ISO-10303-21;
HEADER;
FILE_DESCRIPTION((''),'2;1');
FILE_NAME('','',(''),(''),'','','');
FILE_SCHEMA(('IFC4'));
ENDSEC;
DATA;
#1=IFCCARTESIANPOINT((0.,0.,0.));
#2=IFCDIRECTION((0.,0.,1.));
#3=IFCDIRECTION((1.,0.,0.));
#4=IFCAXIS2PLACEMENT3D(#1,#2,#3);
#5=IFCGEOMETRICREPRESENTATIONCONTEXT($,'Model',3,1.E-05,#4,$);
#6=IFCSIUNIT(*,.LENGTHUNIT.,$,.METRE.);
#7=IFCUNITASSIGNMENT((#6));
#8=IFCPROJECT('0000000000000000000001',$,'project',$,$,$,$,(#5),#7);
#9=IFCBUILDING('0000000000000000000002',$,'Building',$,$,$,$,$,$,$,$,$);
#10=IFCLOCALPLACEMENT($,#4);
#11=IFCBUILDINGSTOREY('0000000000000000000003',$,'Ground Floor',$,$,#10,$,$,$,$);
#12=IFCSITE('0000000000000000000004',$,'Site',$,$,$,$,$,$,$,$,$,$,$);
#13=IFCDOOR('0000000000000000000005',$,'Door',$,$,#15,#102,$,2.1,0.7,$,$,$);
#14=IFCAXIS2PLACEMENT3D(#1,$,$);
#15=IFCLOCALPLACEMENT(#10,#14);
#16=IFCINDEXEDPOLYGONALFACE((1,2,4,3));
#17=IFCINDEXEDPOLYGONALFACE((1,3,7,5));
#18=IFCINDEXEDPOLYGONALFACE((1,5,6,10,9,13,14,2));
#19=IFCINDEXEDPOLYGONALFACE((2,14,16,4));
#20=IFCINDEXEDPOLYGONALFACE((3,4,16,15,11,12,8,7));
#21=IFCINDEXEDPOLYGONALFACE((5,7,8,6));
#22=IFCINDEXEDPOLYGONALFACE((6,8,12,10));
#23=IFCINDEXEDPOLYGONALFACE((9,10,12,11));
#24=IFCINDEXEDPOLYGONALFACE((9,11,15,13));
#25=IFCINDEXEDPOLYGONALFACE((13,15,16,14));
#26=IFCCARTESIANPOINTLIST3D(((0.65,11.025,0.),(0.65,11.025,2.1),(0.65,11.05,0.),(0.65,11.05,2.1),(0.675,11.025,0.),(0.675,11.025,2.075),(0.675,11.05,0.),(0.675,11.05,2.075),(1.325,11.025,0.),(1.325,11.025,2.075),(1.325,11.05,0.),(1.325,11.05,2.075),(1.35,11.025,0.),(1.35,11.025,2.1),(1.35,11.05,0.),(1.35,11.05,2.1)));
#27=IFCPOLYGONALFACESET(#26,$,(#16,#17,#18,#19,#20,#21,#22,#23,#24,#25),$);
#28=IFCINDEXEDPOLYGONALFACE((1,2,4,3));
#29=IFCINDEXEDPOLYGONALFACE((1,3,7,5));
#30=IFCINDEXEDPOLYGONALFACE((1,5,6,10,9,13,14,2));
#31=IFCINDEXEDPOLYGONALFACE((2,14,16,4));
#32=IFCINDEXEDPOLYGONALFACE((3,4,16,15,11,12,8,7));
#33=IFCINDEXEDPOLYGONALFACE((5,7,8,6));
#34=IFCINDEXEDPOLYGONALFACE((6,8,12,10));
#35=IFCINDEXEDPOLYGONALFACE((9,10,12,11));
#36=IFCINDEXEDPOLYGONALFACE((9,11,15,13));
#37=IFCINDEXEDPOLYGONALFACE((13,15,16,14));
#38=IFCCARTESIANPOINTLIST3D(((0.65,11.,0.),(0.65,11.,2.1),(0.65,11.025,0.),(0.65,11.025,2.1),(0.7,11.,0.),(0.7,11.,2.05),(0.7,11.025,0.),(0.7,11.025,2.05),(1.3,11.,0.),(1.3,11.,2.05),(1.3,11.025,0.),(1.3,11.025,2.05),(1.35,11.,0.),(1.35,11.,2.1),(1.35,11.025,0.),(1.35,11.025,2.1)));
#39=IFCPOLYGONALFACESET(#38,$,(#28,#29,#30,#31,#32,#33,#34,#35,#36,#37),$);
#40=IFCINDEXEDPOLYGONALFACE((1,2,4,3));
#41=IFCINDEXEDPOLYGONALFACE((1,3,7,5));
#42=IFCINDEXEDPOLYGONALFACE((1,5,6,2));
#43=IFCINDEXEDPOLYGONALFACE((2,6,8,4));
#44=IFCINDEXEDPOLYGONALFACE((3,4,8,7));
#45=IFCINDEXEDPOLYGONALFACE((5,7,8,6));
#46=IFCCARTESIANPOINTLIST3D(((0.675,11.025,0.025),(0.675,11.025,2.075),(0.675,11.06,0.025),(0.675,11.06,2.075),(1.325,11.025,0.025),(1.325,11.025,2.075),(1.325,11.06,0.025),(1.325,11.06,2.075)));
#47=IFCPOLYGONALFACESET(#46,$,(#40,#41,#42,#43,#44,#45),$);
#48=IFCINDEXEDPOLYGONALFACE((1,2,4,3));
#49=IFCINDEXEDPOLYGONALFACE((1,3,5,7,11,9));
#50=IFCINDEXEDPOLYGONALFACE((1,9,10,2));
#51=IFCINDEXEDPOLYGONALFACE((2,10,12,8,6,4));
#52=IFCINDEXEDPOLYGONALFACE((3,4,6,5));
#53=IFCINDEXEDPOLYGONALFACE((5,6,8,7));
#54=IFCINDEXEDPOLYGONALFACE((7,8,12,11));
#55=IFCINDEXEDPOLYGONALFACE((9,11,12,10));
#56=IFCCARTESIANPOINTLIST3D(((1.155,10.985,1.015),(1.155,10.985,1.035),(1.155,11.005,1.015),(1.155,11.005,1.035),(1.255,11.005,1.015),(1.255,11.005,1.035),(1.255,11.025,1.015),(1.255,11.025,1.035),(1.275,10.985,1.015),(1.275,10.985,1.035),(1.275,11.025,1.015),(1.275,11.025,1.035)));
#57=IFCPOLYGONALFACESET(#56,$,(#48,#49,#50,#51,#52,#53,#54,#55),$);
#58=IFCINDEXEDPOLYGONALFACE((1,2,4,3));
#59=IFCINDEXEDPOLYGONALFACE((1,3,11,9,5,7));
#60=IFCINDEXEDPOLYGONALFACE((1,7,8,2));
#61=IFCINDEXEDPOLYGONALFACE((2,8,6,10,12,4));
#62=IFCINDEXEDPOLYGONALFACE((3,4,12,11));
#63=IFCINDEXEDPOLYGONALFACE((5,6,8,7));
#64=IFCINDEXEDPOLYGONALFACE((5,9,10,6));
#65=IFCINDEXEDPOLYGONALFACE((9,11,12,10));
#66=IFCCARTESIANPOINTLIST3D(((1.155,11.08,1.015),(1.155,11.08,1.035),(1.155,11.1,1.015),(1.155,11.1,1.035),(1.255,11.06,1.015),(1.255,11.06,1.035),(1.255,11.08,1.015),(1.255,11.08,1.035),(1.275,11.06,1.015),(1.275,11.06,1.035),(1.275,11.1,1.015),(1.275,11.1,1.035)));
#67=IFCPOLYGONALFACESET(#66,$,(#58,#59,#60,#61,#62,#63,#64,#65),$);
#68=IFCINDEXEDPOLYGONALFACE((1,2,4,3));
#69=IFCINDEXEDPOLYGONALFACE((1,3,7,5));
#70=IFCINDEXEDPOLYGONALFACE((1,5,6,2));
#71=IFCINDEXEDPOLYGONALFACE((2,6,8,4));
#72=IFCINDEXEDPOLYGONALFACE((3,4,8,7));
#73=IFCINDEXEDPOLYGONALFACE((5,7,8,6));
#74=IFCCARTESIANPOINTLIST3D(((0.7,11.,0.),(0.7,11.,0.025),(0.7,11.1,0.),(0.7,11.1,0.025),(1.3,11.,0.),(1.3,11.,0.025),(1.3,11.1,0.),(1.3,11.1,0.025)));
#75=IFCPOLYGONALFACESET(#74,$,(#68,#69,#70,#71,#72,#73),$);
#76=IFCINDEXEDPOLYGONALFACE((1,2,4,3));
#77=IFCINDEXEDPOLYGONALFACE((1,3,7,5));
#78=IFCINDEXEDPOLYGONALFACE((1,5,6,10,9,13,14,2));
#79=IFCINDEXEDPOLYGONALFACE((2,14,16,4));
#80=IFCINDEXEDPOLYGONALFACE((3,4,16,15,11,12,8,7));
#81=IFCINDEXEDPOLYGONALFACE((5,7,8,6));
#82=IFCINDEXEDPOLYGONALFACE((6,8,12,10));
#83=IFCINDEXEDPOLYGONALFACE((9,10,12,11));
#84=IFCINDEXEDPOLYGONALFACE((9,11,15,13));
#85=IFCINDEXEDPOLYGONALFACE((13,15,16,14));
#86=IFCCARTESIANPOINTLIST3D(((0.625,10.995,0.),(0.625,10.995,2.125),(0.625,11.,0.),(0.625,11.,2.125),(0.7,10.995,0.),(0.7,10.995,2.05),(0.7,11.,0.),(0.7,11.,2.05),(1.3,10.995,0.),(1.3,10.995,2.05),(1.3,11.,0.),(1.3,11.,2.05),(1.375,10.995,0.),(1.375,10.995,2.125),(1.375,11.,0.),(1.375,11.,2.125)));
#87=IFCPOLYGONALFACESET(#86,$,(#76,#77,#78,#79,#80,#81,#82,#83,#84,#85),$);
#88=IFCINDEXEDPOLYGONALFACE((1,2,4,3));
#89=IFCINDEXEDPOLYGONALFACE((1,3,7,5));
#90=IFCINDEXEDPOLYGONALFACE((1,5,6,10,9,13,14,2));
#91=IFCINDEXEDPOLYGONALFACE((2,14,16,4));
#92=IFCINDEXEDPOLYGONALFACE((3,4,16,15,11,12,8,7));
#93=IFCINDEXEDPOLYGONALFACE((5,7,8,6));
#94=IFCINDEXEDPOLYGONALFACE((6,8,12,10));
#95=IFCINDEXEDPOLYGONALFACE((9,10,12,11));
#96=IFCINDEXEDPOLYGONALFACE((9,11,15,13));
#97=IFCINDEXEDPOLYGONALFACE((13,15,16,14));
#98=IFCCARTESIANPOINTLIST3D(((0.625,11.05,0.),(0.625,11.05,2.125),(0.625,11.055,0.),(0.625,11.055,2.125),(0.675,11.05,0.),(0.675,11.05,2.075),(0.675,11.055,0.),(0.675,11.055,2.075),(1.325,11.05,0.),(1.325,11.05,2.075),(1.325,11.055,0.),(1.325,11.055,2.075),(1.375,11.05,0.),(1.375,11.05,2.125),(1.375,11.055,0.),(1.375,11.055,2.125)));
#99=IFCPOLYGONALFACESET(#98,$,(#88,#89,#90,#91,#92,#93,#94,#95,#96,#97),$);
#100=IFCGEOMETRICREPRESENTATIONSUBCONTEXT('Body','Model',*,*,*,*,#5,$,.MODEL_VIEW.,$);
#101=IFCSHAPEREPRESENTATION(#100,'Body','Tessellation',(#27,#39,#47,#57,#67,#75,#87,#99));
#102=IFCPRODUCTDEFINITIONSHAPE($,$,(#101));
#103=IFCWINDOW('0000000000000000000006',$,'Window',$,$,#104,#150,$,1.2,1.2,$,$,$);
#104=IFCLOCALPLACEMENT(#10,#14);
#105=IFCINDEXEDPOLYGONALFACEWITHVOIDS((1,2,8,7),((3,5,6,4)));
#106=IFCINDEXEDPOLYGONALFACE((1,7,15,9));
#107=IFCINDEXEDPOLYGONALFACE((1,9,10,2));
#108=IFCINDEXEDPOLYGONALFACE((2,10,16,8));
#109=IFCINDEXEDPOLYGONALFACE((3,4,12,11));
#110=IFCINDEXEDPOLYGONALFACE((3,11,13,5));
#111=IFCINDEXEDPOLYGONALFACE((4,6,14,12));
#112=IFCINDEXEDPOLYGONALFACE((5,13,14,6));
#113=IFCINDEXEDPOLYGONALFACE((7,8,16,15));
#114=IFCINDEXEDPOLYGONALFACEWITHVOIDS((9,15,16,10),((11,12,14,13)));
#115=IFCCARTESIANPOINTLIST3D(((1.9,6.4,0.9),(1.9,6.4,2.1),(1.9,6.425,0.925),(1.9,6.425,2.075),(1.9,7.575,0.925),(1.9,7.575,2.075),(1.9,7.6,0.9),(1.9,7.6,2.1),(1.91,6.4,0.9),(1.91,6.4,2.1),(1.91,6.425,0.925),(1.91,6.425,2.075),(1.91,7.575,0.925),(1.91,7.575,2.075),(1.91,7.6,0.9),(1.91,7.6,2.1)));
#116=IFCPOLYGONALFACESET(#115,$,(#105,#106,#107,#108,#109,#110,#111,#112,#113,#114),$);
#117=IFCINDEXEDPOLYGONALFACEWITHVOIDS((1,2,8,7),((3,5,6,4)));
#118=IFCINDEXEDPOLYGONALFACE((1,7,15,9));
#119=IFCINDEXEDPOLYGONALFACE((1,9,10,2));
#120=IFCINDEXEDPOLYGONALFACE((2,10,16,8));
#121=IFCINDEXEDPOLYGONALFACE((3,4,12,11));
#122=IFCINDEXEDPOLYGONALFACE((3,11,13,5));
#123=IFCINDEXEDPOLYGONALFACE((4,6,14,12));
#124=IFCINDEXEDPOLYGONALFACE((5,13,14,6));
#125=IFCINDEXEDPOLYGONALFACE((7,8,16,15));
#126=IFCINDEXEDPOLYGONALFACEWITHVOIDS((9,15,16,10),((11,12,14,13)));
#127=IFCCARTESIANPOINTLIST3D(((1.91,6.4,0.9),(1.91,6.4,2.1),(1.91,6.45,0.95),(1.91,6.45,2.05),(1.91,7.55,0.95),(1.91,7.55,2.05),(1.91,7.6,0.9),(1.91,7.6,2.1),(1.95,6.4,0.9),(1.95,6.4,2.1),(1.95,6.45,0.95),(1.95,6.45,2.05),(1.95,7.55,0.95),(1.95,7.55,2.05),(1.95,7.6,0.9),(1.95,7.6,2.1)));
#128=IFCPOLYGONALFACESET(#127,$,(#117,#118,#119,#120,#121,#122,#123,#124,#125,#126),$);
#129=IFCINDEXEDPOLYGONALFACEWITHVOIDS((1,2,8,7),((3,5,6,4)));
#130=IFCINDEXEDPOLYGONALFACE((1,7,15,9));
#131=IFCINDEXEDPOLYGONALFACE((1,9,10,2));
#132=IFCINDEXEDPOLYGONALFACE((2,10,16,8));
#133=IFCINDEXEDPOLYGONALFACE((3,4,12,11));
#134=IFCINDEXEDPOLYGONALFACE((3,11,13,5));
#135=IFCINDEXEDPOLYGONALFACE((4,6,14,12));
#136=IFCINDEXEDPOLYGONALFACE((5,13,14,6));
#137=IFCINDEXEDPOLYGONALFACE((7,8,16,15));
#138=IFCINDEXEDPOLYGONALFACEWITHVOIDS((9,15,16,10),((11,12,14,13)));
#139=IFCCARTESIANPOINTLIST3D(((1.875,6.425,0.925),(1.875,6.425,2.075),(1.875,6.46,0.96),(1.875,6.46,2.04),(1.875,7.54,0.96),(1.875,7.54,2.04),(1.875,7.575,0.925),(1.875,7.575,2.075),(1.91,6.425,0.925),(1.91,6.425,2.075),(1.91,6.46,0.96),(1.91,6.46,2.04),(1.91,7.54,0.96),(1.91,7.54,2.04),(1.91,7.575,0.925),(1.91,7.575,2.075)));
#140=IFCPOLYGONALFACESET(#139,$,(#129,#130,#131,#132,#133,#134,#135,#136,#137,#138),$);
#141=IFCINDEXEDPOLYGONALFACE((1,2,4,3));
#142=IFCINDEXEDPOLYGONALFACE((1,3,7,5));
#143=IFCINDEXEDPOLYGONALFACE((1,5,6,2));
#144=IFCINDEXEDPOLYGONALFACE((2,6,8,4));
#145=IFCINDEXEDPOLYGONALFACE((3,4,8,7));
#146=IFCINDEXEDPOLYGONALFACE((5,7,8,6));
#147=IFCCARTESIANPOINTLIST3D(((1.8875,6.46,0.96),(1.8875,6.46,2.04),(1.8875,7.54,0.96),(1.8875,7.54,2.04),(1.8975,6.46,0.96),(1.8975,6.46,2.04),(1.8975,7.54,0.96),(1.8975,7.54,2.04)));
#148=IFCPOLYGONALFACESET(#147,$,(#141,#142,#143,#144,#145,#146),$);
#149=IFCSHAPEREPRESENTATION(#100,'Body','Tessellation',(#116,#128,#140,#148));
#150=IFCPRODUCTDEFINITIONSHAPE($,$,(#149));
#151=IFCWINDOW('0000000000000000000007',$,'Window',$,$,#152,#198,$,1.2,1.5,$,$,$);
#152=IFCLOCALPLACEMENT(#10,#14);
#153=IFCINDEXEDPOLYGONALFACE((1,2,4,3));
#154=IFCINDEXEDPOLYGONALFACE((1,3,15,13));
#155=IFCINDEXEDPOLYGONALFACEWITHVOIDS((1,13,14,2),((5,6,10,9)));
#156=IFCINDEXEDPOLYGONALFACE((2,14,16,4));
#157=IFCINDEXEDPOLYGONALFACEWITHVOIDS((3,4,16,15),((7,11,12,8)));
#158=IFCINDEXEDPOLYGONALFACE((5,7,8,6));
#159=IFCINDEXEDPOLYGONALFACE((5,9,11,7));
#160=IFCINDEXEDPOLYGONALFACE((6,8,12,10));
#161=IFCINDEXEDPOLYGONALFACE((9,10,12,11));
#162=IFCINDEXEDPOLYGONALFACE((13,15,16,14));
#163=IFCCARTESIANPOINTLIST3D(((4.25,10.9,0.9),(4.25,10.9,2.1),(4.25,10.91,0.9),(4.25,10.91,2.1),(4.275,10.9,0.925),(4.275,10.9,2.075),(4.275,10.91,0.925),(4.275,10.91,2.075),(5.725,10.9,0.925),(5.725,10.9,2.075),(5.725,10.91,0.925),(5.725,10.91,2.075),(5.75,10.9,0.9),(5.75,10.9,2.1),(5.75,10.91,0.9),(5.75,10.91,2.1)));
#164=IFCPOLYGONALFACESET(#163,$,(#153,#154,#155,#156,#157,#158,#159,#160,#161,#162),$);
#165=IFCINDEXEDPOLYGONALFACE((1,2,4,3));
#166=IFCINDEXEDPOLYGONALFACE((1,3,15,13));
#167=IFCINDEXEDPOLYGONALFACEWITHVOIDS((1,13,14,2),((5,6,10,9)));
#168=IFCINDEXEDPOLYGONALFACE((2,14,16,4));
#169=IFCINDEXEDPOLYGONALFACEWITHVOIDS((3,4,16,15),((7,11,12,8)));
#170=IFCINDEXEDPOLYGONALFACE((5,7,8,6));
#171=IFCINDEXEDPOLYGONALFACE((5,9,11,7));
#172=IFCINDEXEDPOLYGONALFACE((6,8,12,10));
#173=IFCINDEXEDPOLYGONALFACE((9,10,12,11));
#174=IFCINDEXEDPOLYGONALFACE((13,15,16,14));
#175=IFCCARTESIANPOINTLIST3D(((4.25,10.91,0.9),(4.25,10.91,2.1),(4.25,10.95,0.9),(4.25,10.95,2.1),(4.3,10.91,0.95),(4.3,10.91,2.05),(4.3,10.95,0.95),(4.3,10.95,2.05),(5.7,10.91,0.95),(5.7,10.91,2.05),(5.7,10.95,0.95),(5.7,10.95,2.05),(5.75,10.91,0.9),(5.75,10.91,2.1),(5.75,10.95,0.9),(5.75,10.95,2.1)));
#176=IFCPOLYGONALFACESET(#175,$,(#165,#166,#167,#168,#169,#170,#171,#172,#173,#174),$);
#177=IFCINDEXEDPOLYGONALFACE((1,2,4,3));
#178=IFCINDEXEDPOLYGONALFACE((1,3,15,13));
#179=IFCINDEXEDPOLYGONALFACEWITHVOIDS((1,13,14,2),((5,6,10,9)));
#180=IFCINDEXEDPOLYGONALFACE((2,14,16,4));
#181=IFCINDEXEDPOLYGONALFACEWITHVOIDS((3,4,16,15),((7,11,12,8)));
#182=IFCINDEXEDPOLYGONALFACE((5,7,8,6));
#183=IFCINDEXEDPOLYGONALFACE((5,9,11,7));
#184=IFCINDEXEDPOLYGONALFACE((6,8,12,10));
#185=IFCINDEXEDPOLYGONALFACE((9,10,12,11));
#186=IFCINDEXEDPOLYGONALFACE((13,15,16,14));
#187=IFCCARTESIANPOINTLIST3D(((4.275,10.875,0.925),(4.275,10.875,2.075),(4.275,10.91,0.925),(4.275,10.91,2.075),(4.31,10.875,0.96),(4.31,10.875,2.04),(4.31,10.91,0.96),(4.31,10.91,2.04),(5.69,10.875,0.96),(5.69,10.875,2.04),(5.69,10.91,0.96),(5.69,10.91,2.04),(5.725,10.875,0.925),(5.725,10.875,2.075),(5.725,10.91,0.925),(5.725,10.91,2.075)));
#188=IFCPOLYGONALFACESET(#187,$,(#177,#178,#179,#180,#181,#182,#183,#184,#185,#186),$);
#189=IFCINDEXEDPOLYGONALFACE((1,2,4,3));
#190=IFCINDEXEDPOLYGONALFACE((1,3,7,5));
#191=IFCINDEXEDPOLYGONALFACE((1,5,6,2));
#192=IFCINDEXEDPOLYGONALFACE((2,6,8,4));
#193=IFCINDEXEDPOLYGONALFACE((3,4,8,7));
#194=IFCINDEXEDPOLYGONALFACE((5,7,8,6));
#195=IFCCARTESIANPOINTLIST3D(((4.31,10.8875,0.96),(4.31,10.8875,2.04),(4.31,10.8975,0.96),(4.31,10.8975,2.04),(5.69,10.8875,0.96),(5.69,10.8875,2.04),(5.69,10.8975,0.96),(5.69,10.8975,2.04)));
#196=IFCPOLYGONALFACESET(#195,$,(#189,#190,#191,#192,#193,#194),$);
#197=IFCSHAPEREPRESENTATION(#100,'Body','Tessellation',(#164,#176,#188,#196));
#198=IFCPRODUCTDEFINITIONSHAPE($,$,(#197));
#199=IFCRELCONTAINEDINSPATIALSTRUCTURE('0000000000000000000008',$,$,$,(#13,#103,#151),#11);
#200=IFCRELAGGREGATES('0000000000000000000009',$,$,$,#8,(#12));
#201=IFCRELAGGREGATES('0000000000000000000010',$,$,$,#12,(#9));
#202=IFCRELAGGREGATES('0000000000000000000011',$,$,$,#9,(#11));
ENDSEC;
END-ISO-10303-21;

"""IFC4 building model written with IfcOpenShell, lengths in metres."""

from ifc_helpers import new_model, si_unit, frame, origin_with_axes, place, context, subcontext, project, spatial, line, indexed_curve, outline, extrude, element, save


model = new_model("IFC4")

# Units and contexts
model_context = context("Model", 3, precision=1e-05, world=origin_with_axes())
body_context = subcontext(model_context, "Body", "Model", "MODEL_VIEW")
ifc_project = project(units=[si_unit("LENGTHUNIT", "METRE")], contexts=[model_context])

# Site, building, storey
site = spatial("IfcSite", under=ifc_project, Name="Site")
building = spatial("IfcBuilding", under=site, Name="Building")
storey_placement = place(None, origin_with_axes())
storey = spatial("IfcBuildingStorey", under=building, at=storey_placement, Name="Ground Floor")

# Door
door_1_placement = place(storey_placement, frame((0.65, 11.0, 0.0), z_axis=(0.0, 0.0, 1.0), x_axis=(1.0, 0.0, 0.0)))
element("IfcDoor", 1, at=door_1_placement, inside=storey, Name="Door", OverallHeight=2.1, OverallWidth=0.7, context=body_context, shape_type="SweptSolid", body=[
    extrude(outline(indexed_curve([(0.0, 0.0), (0.0, 2.1), (0.7, 2.1), (0.7, 0.0), (0.675, 0.0), (0.675, 2.075), (0.025, 2.075), (0.025, 0.0)], segments=[line(1, 2, 3, 4, 5, 6, 7, 8, 1)])), frame((0.0, 0.025, 0.0), z_axis=(0.0, -1.0, 0.0), x_axis=(1.0, 0.0, 0.0)), (0.0, 0.0, -1.0), 0.025),
    extrude(outline(indexed_curve([(0.0, 0.0), (0.0, 2.1), (0.7, 2.1), (0.7, 0.0), (0.65, 0.0), (0.65, 2.05), (0.05, 2.05), (0.05, 0.0)], segments=[line(1, 2, 3, 4, 5, 6, 7, 8, 1)])), frame((0.0, 0.0, 0.0), z_axis=(0.0, -1.0, 0.0), x_axis=(1.0, 0.0, 0.0)), (0.0, 0.0, -1.0), 0.025),
    extrude(outline(indexed_curve([(0.0, 0.0), (0.65, 0.0), (0.65, 0.035), (0.0, 0.035)], segments=[line(1, 2, 3, 4, 1)])), frame((0.025, 0.025, 0.025), z_axis=(0.0, 0.0, 1.0), x_axis=(1.0, 0.0, 0.0)), (0.0, 0.0, 1.0), 2.05),
    extrude(outline(indexed_curve([(0.0, 0.0), (0.0, -0.04), (-0.12, -0.04), (-0.12, -0.02), (-0.02, -0.02), (-0.02, 0.0)], segments=[line(1, 2, 3, 4, 5, 6, 1)])), frame((0.625, 0.025, 1.015), z_axis=(0.0, 0.0, 1.0), x_axis=(1.0, 0.0, 0.0)), (0.0, 0.0, 1.0), 0.02),
    extrude(outline(indexed_curve([(0.0, 0.0), (0.0, 0.04), (-0.12, 0.04), (-0.12, 0.02), (-0.02, 0.02), (-0.02, 0.0)], segments=[line(1, 2, 3, 4, 5, 6, 1)])), frame((0.625, 0.06, 1.015), z_axis=(0.0, 0.0, 1.0), x_axis=(1.0, 0.0, 0.0)), (0.0, 0.0, 1.0), 0.02),
    extrude(outline(indexed_curve([(0.0, 0.0), (0.6, 0.0), (0.6, 0.1), (0.0, 0.1)], segments=[line(1, 2, 3, 4, 1)])), frame((0.05, 0.0, 0.0), z_axis=(0.0, 0.0, 1.0), x_axis=(1.0, 0.0, 0.0)), (0.0, 0.0, 1.0), 0.025),
    extrude(outline(indexed_curve([(0.0, 0.0), (0.0, 2.125), (0.75, 2.125), (0.75, 0.0), (0.675, 0.0), (0.675, 2.05), (0.075, 2.05), (0.075, 0.0)], segments=[line(1, 2, 3, 4, 5, 6, 7, 8, 1)])), frame((-0.025, -0.005, 0.0), z_axis=(0.0, -1.0, 0.0), x_axis=(1.0, 0.0, 0.0)), (0.0, 0.0, -1.0), 0.005),
    extrude(outline(indexed_curve([(0.0, 0.0), (0.0, 2.125), (0.75, 2.125), (0.75, 0.0), (0.7, 0.0), (0.7, 2.075), (0.05, 2.075), (0.05, 0.0)], segments=[line(1, 2, 3, 4, 5, 6, 7, 8, 1)])), frame((-0.025, 0.05, 0.0), z_axis=(0.0, -1.0, 0.0), x_axis=(1.0, 0.0, 0.0)), (0.0, 0.0, -1.0), 0.005),
])

# Windows
window_1_placement = place(storey_placement, frame((2.0, 6.4, 0.9), z_axis=(0.0, 0.0, 1.0), x_axis=(0.0, 1.0, 0.0)))
element("IfcWindow", 2, at=window_1_placement, inside=storey, Name="Window", OverallHeight=1.2, OverallWidth=1.2, context=body_context, shape_type="SweptSolid", body=[
    extrude(outline(indexed_curve([(0.0, 0.0), (1.2, 0.0), (1.2, 1.2), (0.0, 1.2)], segments=[line(1, 2, 3, 4, 1)]), holes=[indexed_curve([(0.025, 0.025), (1.175, 0.025), (1.175, 1.175), (0.025, 1.175)], segments=[line(1, 2, 3, 4, 1)])]), frame((0.0, 0.09, 0.0), z_axis=(0.0, -1.0, 0.0), x_axis=(1.0, 0.0, 0.0)), (0.0, 0.0, -1.0), 0.01),
    extrude(outline(indexed_curve([(0.0, 0.0), (1.2, 0.0), (1.2, 1.2), (0.0, 1.2)], segments=[line(1, 2, 3, 4, 1)]), holes=[indexed_curve([(0.05, 0.05), (1.15, 0.05), (1.15, 1.15), (0.05, 1.15)], segments=[line(1, 2, 3, 4, 1)])]), frame((0.0, 0.05, 0.0), z_axis=(0.0, -1.0, 0.0), x_axis=(1.0, 0.0, 0.0)), (0.0, 0.0, -1.0), 0.04),
    extrude(outline(indexed_curve([(0.0, 0.0), (1.15, 0.0), (1.15, 1.15), (0.0, 1.15)], segments=[line(1, 2, 3, 4, 1)]), holes=[indexed_curve([(0.035, 0.035), (1.115, 0.035), (1.115, 1.115), (0.035, 1.115)], segments=[line(1, 2, 3, 4, 1)])]), frame((0.025, 0.09, 0.025), z_axis=(0.0, -1.0, 0.0), x_axis=(1.0, 0.0, 0.0)), (0.0, 0.0, -1.0), 0.035),
    extrude(outline(indexed_curve([(0.035, 0.035), (1.115, 0.035), (1.115, 1.115), (0.035, 1.115)], segments=[line(1, 2, 3, 4, 1)])), frame((0.025, 0.1025, 0.025), z_axis=(0.0, -1.0, 0.0), x_axis=(1.0, 0.0, 0.0)), (0.0, 0.0, -1.0), 0.01),
])
window_2_placement = place(storey_placement, frame((5.75, 11.0, 0.9), z_axis=(0.0, 0.0, 1.0), x_axis=(-1.0, 0.0, 0.0)))
element("IfcWindow", 3, at=window_2_placement, inside=storey, Name="Window", OverallHeight=1.2, OverallWidth=1.5, context=body_context, shape_type="SweptSolid", body=[
    extrude(outline(indexed_curve([(0.0, 0.0), (1.5, 0.0), (1.5, 1.2), (0.0, 1.2)], segments=[line(1, 2, 3, 4, 1)]), holes=[indexed_curve([(0.025, 0.025), (1.475, 0.025), (1.475, 1.175), (0.025, 1.175)], segments=[line(1, 2, 3, 4, 1)])]), frame((0.0, 0.09, 0.0), z_axis=(0.0, -1.0, 0.0), x_axis=(1.0, 0.0, 0.0)), (0.0, 0.0, -1.0), 0.01),
    extrude(outline(indexed_curve([(0.0, 0.0), (1.5, 0.0), (1.5, 1.2), (0.0, 1.2)], segments=[line(1, 2, 3, 4, 1)]), holes=[indexed_curve([(0.05, 0.05), (1.45, 0.05), (1.45, 1.15), (0.05, 1.15)], segments=[line(1, 2, 3, 4, 1)])]), frame((0.0, 0.05, 0.0), z_axis=(0.0, -1.0, 0.0), x_axis=(1.0, 0.0, 0.0)), (0.0, 0.0, -1.0), 0.04),
    extrude(outline(indexed_curve([(0.0, 0.0), (1.45, 0.0), (1.45, 1.15), (0.0, 1.15)], segments=[line(1, 2, 3, 4, 1)]), holes=[indexed_curve([(0.035, 0.035), (1.415, 0.035), (1.415, 1.115), (0.035, 1.115)], segments=[line(1, 2, 3, 4, 1)])]), frame((0.025, 0.09, 0.025), z_axis=(0.0, -1.0, 0.0), x_axis=(1.0, 0.0, 0.0)), (0.0, 0.0, -1.0), 0.035),
    extrude(outline(indexed_curve([(0.035, 0.035), (1.415, 0.035), (1.415, 1.115), (0.035, 1.115)], segments=[line(1, 2, 3, 4, 1)])), frame((0.025, 0.1025, 0.025), z_axis=(0.0, -1.0, 0.0), x_axis=(1.0, 0.0, 0.0)), (0.0, 0.0, -1.0), 0.01),
])

save(model, "model.ifc")
